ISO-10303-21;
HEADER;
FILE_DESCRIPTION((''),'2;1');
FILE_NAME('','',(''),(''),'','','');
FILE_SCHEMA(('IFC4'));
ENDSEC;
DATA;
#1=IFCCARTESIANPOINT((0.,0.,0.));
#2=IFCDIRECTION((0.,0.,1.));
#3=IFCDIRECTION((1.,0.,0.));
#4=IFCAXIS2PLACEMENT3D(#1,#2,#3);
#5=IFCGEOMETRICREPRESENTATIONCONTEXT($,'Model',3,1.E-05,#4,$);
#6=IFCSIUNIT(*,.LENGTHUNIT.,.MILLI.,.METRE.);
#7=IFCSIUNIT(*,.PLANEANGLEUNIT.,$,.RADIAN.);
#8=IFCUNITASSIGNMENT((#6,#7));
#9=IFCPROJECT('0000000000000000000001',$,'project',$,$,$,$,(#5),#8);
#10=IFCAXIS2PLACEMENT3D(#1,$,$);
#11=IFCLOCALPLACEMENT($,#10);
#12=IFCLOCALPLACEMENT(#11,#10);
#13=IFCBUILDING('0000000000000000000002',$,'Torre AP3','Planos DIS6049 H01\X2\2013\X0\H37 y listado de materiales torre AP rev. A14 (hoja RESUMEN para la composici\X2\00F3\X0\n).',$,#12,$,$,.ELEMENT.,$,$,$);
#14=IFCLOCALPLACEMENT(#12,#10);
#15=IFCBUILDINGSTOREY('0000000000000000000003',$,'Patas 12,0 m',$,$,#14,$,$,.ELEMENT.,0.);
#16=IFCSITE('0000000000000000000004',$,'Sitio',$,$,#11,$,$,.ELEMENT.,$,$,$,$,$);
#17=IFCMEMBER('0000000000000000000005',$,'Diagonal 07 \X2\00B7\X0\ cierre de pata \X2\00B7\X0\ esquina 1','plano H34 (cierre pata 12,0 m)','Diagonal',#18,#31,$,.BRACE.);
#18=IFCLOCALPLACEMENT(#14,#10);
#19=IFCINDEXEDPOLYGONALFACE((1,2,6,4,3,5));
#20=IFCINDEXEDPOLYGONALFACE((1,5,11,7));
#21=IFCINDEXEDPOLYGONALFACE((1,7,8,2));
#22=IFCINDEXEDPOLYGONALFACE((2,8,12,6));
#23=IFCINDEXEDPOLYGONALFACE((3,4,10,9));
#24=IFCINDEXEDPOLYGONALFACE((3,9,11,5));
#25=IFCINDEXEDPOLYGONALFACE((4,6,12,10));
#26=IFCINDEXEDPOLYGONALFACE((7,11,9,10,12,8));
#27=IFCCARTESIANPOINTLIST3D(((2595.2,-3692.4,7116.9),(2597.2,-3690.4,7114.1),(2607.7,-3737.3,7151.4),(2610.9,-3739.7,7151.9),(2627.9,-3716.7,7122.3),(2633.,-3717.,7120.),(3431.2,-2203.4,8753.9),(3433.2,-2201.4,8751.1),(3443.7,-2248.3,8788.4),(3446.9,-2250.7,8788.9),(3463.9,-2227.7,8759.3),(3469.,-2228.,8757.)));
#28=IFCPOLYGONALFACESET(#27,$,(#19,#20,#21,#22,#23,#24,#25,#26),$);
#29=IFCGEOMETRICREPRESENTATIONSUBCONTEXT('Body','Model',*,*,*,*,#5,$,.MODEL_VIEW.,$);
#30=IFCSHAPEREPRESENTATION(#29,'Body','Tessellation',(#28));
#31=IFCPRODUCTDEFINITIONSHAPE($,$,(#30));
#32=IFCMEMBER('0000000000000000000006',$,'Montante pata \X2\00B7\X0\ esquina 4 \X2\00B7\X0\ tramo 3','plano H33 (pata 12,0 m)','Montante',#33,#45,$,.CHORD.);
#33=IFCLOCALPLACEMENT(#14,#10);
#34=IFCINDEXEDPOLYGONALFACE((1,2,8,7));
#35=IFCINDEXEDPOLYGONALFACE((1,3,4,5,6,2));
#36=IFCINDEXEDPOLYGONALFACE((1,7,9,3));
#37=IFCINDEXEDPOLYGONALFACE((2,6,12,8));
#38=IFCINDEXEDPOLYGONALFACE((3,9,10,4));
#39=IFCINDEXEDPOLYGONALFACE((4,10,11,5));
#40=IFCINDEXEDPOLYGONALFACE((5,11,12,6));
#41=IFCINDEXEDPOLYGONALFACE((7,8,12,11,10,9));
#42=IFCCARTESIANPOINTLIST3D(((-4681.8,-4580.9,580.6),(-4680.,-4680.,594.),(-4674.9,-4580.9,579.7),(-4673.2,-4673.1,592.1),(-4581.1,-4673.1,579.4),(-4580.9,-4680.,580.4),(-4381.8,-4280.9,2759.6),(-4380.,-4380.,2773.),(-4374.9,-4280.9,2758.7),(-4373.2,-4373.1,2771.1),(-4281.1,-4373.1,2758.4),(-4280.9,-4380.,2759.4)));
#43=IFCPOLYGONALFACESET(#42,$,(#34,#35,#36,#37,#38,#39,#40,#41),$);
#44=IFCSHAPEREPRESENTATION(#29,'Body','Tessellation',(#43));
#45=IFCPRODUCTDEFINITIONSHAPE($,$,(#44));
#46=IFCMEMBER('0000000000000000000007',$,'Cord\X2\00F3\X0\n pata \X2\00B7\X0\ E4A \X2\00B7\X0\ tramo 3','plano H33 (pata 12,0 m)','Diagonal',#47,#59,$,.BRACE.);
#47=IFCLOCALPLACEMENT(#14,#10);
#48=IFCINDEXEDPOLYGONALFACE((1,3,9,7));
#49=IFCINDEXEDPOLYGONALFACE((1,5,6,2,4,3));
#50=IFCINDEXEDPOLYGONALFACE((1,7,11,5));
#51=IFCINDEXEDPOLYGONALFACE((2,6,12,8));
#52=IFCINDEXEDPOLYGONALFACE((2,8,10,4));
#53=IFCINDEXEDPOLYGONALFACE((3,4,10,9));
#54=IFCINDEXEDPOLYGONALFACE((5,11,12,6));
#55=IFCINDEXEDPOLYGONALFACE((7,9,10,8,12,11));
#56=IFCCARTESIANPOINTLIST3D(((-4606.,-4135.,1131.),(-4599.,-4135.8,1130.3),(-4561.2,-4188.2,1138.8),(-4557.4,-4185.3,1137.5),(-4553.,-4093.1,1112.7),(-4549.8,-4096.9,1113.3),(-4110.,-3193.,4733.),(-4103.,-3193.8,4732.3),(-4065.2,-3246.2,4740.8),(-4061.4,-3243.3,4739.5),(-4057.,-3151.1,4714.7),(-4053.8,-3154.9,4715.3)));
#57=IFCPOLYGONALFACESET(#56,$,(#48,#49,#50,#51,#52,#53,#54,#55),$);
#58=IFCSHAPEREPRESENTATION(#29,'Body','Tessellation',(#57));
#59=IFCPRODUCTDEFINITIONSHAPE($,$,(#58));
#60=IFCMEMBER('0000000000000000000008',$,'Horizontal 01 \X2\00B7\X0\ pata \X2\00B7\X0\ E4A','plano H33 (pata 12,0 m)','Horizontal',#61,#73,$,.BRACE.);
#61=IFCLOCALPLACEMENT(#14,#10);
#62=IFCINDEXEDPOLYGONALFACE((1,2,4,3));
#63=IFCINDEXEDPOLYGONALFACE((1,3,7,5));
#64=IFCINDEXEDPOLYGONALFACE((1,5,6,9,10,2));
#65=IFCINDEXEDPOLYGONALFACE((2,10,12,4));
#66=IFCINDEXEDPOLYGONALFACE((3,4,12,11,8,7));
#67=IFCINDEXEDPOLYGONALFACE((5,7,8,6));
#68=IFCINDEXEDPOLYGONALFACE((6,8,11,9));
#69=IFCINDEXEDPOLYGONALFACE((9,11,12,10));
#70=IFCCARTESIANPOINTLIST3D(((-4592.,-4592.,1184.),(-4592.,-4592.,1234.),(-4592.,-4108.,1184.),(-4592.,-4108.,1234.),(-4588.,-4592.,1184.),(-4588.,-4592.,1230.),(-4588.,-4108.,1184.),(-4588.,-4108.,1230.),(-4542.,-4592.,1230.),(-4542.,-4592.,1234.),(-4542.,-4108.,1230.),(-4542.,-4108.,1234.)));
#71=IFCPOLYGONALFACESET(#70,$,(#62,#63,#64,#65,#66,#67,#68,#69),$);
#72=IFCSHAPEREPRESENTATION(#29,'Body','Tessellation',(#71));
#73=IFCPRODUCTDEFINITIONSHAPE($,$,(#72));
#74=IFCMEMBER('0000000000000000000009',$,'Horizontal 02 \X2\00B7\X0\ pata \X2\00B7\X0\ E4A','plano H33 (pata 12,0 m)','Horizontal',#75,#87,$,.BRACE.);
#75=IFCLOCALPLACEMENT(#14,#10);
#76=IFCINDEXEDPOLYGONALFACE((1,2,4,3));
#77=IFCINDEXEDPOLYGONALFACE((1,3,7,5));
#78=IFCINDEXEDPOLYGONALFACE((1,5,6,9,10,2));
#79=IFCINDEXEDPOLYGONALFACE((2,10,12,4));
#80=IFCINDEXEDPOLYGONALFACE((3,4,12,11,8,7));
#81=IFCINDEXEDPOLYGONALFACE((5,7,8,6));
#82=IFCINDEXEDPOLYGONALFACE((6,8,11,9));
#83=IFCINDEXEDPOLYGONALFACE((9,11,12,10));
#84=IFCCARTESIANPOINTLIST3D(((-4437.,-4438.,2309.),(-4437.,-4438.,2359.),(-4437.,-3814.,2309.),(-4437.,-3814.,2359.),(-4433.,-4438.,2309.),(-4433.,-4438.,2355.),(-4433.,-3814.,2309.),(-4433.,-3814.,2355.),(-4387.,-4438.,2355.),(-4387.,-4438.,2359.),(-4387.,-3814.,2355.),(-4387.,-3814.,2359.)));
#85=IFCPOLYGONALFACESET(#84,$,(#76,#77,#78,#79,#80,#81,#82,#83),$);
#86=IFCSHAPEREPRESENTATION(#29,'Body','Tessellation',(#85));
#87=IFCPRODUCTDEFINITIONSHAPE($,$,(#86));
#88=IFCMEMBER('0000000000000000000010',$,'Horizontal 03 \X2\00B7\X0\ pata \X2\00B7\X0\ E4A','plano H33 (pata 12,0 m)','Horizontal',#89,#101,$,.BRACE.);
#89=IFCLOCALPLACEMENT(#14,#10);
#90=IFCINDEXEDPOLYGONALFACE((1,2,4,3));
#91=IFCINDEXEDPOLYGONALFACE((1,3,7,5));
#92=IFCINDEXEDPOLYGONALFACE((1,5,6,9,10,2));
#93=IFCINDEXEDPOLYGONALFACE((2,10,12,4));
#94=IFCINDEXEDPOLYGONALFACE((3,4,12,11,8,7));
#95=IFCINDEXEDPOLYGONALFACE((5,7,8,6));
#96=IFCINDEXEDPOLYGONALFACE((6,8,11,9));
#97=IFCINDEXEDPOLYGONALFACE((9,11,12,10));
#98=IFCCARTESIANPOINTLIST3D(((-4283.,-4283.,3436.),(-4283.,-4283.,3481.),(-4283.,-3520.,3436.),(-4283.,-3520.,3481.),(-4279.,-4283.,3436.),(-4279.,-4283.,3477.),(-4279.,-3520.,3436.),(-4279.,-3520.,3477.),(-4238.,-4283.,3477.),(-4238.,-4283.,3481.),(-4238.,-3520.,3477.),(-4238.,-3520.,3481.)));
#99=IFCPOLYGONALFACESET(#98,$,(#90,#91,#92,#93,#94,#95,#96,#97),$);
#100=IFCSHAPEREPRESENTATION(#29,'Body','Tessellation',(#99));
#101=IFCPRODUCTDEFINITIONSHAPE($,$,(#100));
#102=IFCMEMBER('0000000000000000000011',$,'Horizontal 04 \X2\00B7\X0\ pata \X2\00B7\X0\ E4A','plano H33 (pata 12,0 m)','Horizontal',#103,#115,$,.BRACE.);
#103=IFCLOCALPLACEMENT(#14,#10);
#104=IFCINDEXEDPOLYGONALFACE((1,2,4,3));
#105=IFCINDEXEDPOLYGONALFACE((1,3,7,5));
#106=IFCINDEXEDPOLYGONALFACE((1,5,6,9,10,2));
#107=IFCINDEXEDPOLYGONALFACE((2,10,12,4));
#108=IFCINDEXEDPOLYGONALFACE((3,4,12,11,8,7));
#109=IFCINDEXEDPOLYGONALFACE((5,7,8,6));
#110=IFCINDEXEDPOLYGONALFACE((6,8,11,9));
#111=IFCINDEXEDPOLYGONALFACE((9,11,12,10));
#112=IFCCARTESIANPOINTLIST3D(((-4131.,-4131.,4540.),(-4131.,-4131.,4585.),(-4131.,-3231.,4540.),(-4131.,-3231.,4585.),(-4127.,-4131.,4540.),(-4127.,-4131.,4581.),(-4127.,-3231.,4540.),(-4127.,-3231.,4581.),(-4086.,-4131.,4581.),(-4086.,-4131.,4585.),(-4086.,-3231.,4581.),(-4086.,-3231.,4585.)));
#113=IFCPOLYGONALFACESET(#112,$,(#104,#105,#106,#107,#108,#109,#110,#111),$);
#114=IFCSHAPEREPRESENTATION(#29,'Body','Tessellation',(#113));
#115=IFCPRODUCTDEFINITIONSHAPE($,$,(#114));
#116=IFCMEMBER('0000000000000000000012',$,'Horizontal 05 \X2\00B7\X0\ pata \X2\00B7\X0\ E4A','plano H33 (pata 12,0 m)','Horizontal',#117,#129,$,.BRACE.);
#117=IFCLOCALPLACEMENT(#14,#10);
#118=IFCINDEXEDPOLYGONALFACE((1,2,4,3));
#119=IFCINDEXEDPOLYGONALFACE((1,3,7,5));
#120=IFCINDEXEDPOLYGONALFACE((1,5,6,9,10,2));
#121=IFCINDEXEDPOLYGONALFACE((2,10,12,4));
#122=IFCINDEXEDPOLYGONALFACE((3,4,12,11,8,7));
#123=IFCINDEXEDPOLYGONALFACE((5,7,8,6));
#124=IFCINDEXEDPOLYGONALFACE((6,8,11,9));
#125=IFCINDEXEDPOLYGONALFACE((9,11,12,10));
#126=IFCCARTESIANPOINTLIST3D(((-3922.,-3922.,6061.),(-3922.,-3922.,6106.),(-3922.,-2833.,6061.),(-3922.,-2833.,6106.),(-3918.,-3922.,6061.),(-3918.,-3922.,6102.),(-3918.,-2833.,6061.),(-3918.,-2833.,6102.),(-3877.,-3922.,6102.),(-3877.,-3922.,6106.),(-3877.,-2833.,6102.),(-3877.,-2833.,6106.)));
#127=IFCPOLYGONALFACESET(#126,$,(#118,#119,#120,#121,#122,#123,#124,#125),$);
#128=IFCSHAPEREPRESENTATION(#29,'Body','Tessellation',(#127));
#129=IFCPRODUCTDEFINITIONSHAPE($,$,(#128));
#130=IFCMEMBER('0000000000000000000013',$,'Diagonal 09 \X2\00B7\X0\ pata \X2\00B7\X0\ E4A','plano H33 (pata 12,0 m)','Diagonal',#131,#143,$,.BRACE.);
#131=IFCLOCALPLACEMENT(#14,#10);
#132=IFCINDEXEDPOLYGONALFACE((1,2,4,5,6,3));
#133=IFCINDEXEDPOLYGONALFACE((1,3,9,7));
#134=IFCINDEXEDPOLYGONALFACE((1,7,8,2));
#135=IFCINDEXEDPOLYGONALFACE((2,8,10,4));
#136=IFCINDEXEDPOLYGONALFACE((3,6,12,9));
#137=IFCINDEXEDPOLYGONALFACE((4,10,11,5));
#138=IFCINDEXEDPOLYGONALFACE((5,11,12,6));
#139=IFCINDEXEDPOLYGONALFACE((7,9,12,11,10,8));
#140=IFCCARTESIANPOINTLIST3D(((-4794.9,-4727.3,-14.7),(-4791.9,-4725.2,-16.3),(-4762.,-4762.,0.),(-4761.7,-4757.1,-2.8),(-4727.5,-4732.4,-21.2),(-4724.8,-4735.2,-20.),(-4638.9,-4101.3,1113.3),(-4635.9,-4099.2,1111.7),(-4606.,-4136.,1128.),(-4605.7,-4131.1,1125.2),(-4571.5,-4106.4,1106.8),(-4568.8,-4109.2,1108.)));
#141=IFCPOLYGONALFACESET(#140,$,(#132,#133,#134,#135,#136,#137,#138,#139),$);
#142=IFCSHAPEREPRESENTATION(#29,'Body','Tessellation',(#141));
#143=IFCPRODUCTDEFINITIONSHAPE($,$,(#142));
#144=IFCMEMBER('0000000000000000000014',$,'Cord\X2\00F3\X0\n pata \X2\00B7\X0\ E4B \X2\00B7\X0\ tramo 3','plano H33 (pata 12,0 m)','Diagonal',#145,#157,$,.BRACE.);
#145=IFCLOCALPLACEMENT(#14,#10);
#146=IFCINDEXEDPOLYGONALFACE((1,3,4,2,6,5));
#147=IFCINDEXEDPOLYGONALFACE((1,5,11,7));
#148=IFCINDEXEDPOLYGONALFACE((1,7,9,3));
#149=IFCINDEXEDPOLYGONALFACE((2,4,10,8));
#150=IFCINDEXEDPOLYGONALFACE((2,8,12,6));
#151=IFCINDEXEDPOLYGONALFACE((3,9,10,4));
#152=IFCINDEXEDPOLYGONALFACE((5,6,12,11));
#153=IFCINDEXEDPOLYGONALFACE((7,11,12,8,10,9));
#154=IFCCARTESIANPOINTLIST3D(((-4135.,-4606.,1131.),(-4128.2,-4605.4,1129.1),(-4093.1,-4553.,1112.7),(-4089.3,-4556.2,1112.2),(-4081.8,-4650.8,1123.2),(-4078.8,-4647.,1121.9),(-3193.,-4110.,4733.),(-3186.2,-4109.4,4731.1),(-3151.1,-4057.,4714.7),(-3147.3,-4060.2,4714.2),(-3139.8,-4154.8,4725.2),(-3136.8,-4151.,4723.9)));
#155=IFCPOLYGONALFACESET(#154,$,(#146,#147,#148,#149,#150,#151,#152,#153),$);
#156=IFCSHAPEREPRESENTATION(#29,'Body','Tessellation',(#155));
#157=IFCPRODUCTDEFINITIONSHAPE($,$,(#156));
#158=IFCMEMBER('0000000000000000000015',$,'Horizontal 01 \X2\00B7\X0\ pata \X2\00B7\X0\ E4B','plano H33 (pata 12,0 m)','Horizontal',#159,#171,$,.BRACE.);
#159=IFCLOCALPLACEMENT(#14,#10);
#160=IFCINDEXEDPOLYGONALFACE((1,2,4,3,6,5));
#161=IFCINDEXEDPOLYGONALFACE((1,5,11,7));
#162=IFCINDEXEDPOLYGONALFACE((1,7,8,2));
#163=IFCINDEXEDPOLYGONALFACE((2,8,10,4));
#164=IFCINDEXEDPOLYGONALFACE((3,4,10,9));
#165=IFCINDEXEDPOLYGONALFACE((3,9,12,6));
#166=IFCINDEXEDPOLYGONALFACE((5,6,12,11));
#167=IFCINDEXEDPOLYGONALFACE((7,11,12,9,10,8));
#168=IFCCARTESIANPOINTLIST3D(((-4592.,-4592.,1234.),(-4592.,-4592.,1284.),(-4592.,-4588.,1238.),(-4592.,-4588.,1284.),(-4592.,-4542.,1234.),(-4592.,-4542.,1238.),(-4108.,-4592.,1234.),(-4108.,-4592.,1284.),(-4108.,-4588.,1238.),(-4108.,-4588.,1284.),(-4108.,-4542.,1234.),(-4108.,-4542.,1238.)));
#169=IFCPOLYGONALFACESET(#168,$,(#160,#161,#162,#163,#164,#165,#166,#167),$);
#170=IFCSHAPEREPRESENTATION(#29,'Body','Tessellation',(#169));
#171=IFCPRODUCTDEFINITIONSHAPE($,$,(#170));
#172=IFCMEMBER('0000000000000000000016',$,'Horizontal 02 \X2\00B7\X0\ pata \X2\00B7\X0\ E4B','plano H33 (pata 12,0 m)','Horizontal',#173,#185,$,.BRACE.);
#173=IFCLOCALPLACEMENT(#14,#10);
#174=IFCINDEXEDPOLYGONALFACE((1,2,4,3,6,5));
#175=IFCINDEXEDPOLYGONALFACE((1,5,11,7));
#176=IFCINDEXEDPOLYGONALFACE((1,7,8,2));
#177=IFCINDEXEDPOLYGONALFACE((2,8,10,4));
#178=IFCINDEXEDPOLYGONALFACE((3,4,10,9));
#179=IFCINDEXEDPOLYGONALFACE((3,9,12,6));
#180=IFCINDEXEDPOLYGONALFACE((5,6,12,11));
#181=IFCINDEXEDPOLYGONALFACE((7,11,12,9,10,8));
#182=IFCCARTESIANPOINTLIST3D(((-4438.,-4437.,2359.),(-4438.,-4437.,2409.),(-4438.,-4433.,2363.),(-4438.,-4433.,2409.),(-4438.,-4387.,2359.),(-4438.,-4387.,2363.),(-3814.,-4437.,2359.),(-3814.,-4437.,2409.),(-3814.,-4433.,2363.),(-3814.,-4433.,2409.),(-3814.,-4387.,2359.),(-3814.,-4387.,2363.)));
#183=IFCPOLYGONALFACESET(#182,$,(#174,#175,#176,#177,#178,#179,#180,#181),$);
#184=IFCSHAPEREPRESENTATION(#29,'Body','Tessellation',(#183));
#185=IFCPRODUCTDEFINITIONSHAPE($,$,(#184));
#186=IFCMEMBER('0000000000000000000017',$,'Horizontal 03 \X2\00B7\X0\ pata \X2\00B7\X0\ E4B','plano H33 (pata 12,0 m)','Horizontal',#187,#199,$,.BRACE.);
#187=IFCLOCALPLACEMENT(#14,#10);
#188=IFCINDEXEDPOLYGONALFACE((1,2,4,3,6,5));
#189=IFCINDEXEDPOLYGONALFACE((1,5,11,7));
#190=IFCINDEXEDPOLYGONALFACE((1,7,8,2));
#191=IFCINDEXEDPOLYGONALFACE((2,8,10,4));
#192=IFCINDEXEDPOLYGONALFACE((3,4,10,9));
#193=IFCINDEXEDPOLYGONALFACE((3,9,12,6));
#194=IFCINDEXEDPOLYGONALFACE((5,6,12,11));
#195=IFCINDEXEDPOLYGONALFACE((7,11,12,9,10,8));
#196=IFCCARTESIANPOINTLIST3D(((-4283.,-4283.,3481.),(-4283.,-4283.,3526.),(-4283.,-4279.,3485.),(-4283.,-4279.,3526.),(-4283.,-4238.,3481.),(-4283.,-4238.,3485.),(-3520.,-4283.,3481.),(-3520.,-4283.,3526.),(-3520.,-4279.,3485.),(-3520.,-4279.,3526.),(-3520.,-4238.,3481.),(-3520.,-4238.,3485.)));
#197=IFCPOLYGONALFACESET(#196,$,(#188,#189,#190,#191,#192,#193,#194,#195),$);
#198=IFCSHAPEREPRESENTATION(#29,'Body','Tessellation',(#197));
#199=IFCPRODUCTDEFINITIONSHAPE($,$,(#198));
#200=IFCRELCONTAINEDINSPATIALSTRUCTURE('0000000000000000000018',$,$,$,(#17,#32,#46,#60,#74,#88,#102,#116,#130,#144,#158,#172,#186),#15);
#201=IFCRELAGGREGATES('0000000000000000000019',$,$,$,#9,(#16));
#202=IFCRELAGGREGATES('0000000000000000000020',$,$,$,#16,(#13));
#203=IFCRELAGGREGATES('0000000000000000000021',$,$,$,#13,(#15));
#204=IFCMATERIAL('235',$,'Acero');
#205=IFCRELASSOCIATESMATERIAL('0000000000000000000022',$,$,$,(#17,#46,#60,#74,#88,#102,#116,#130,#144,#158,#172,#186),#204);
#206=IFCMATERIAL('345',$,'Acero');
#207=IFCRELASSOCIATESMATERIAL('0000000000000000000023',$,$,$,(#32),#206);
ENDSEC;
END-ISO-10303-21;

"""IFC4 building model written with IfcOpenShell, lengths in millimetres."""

from ifc_helpers import new_model, si_unit, frame, frame_2d, origin, origin_with_axes, place, context, subcontext, project, spatial, l_section, extrude, material, element, save


model = new_model("IFC4")

# Units and contexts
model_context = context("Model", 3, precision=1e-05, world=origin_with_axes())
body_context = subcontext(model_context, "Body", "Model", "MODEL_VIEW")
ifc_project = project(units=[si_unit("LENGTHUNIT", "METRE", prefix="MILLI"), si_unit("PLANEANGLEUNIT", "RADIAN")], contexts=[model_context])

# Site, building, storey
site_placement = place(None, origin())
site = spatial("IfcSite", under=ifc_project, at=site_placement, Name="Sitio", CompositionType="ELEMENT")
building_placement = place(site_placement, origin())
building = spatial("IfcBuilding", under=site, at=building_placement, Name="Torre AP3", Description="Planos DIS6049 H01–H37 y listado de materiales torre AP rev. A14 (hoja RESUMEN para la composición).", CompositionType="ELEMENT")
storey_placement = place(building_placement, origin())
storey = spatial("IfcBuildingStorey", under=building, at=storey_placement, Name="Patas 12,0 m", CompositionType="ELEMENT", Elevation=0.0)

# Members
ifc_material_1 = material(Name="235", Category="Acero")
member_1_placement = place(storey_placement, frame((2633.0, -3717.0, 7120.0), z_axis=(0.353407, 0.629454, 0.692019), x_axis=(-0.795946, 0.591004, -0.13109)))
element("IfcMember", 1, at=member_1_placement, inside=storey, material=ifc_material_1, Name="Diagonal 07 · cierre de pata · esquina 1", Description="plano H34 (cierre pata 12,0 m)", ObjectType="Diagonal", PredefinedType="BRACE", context=body_context, shape_type="SweptSolid", body=[
    extrude(l_section(Depth=45.0, Width=45.0, Thickness=4.0, at=frame_2d((22.5, 22.5))), None, (0.0, 0.0, 1.0), 2365.5),
])
ifc_material_2 = material(Name="345", Category="Acero")
member_2_placement = place(storey_placement, frame((-4380.0, -4380.0, 2773.0), z_axis=(-0.13514, -0.13514, -0.981567), x_axis=(-0.018432, 0.990827, -0.133877)))
element("IfcMember", 2, at=member_2_placement, inside=storey, material=ifc_material_2, Name="Montante pata · esquina 4 · tramo 3", Description="plano H33 (pata 12,0 m)", ObjectType="Montante", PredefinedType="CHORD", context=body_context, shape_type="SweptSolid", body=[
    extrude(l_section(Depth=100.0, Width=100.0, Thickness=7.0, at=frame_2d((50.0, 50.0))), None, (0.0, 0.0, 1.0), 2219.9),
])
member_3_placement = place(storey_placement, frame((-4110.0, -3193.0, 4733.0), z_axis=(-0.132054, -0.250797, -0.958991), x_axis=(0.757312, 0.598693, -0.260854)))
element("IfcMember", 3, at=member_3_placement, inside=storey, material=ifc_material_1, Name="Cordón pata · E4A · tramo 3", Description="plano H33 (pata 12,0 m)", ObjectType="Diagonal", PredefinedType="BRACE", context=body_context, shape_type="SweptSolid", body=[
    extrude(l_section(Depth=70.0, Width=70.0, Thickness=5.0, at=frame_2d((35.0, 35.0))), None, (0.0, 0.0, 1.0), 3756.0),
])
member_4_placement = place(storey_placement, frame((-4592.0, -4592.0, 1234.0), z_axis=(0.0, 1.0, 0.0), x_axis=(1.0, 0.0, 0.0)))
element("IfcMember", 4, at=member_4_placement, inside=storey, material=ifc_material_1, Name="Horizontal 01 · pata · E4A", Description="plano H33 (pata 12,0 m)", ObjectType="Horizontal", PredefinedType="BRACE", context=body_context, shape_type="SweptSolid", body=[
    extrude(l_section(Depth=50.0, Width=50.0, Thickness=4.0, at=frame_2d((25.0, 25.0))), None, (0.0, 0.0, 1.0), 484.0),
])
member_5_placement = place(storey_placement, frame((-4437.0, -4438.0, 2359.0), z_axis=(0.0, 1.0, 0.0), x_axis=(1.0, 0.0, 0.0)))
element("IfcMember", 5, at=member_5_placement, inside=storey, material=ifc_material_1, Name="Horizontal 02 · pata · E4A", Description="plano H33 (pata 12,0 m)", ObjectType="Horizontal", PredefinedType="BRACE", context=body_context, shape_type="SweptSolid", body=[
    extrude(l_section(Depth=50.0, Width=50.0, Thickness=4.0, at=frame_2d((25.0, 25.0))), None, (0.0, 0.0, 1.0), 624.0),
])
member_6_placement = place(storey_placement, frame((-4283.0, -4283.0, 3481.0), z_axis=(0.0, 1.0, 0.0), x_axis=(1.0, 0.0, 0.0)))
element("IfcMember", 6, at=member_6_placement, inside=storey, material=ifc_material_1, Name="Horizontal 03 · pata · E4A", Description="plano H33 (pata 12,0 m)", ObjectType="Horizontal", PredefinedType="BRACE", context=body_context, shape_type="SweptSolid", body=[
    extrude(l_section(Depth=45.0, Width=45.0, Thickness=4.0, at=frame_2d((22.5, 22.5))), None, (0.0, 0.0, 1.0), 763.0),
])
member_7_placement = place(storey_placement, frame((-4131.0, -4131.0, 4585.0), z_axis=(0.0, 1.0, 0.0), x_axis=(1.0, 0.0, 0.0)))
element("IfcMember", 7, at=member_7_placement, inside=storey, material=ifc_material_1, Name="Horizontal 04 · pata · E4A", Description="plano H33 (pata 12,0 m)", ObjectType="Horizontal", PredefinedType="BRACE", context=body_context, shape_type="SweptSolid", body=[
    extrude(l_section(Depth=45.0, Width=45.0, Thickness=4.0, at=frame_2d((22.5, 22.5))), None, (0.0, 0.0, 1.0), 900.0),
])
member_8_placement = place(storey_placement, frame((-3922.0, -3922.0, 6106.0), z_axis=(0.0, 1.0, 0.0), x_axis=(1.0, 0.0, 0.0)))
element("IfcMember", 8, at=member_8_placement, inside=storey, material=ifc_material_1, Name="Horizontal 05 · pata · E4A", Description="plano H33 (pata 12,0 m)", ObjectType="Horizontal", PredefinedType="BRACE", context=body_context, shape_type="SweptSolid", body=[
    extrude(l_section(Depth=45.0, Width=45.0, Thickness=4.0, at=frame_2d((22.5, 22.5))), None, (0.0, 0.0, 1.0), 1089.0),
])
member_9_placement = place(storey_placement, frame((-4762.0, -4762.0, 0.0), z_axis=(0.12005, 0.481739, 0.868053), x_axis=(0.743093, 0.53622, -0.400351)))
element("IfcMember", 9, at=member_9_placement, inside=storey, material=ifc_material_1, Name="Diagonal 09 · pata · E4A", Description="plano H33 (pata 12,0 m)", ObjectType="Diagonal", PredefinedType="BRACE", context=body_context, shape_type="SweptSolid", body=[
    extrude(l_section(Depth=50.0, Width=50.0, Thickness=4.0, at=frame_2d((25.0, 25.0))), None, (0.0, 0.0, 1.0), 1299.5),
])
member_10_placement = place(storey_placement, frame((-3193.0, -4110.0, 4733.0), z_axis=(-0.250797, -0.132054, -0.958991), x_axis=(0.598693, 0.757312, -0.260854)))
element("IfcMember", 10, at=member_10_placement, inside=storey, material=ifc_material_1, Name="Cordón pata · E4B · tramo 3", Description="plano H33 (pata 12,0 m)", ObjectType="Diagonal", PredefinedType="BRACE", context=body_context, shape_type="SweptSolid", body=[
    extrude(l_section(Depth=70.0, Width=70.0, Thickness=5.0, at=frame_2d((35.0, 35.0))), None, (0.0, 0.0, 1.0), 3756.0),
])
member_11_placement = place(storey_placement, frame((-4592.0, -4592.0, 1234.0), z_axis=(1.0, 0.0, 0.0), x_axis=(0.0, 1.0, 0.0)))
element("IfcMember", 11, at=member_11_placement, inside=storey, material=ifc_material_1, Name="Horizontal 01 · pata · E4B", Description="plano H33 (pata 12,0 m)", ObjectType="Horizontal", PredefinedType="BRACE", context=body_context, shape_type="SweptSolid", body=[
    extrude(l_section(Depth=50.0, Width=50.0, Thickness=4.0, at=frame_2d((25.0, 25.0))), None, (0.0, 0.0, 1.0), 484.0),
])
member_12_placement = place(storey_placement, frame((-4438.0, -4437.0, 2359.0), z_axis=(1.0, 0.0, 0.0), x_axis=(0.0, 1.0, 0.0)))
element("IfcMember", 12, at=member_12_placement, inside=storey, material=ifc_material_1, Name="Horizontal 02 · pata · E4B", Description="plano H33 (pata 12,0 m)", ObjectType="Horizontal", PredefinedType="BRACE", context=body_context, shape_type="SweptSolid", body=[
    extrude(l_section(Depth=50.0, Width=50.0, Thickness=4.0, at=frame_2d((25.0, 25.0))), None, (0.0, 0.0, 1.0), 624.0),
])
member_13_placement = place(storey_placement, frame((-4283.0, -4283.0, 3481.0), z_axis=(1.0, 0.0, 0.0), x_axis=(0.0, 1.0, 0.0)))
element("IfcMember", 13, at=member_13_placement, inside=storey, material=ifc_material_1, Name="Horizontal 03 · pata · E4B", Description="plano H33 (pata 12,0 m)", ObjectType="Horizontal", PredefinedType="BRACE", context=body_context, shape_type="SweptSolid", body=[
    extrude(l_section(Depth=45.0, Width=45.0, Thickness=4.0, at=frame_2d((22.5, 22.5))), None, (0.0, 0.0, 1.0), 763.0),
])

save(model, "model.ifc")
